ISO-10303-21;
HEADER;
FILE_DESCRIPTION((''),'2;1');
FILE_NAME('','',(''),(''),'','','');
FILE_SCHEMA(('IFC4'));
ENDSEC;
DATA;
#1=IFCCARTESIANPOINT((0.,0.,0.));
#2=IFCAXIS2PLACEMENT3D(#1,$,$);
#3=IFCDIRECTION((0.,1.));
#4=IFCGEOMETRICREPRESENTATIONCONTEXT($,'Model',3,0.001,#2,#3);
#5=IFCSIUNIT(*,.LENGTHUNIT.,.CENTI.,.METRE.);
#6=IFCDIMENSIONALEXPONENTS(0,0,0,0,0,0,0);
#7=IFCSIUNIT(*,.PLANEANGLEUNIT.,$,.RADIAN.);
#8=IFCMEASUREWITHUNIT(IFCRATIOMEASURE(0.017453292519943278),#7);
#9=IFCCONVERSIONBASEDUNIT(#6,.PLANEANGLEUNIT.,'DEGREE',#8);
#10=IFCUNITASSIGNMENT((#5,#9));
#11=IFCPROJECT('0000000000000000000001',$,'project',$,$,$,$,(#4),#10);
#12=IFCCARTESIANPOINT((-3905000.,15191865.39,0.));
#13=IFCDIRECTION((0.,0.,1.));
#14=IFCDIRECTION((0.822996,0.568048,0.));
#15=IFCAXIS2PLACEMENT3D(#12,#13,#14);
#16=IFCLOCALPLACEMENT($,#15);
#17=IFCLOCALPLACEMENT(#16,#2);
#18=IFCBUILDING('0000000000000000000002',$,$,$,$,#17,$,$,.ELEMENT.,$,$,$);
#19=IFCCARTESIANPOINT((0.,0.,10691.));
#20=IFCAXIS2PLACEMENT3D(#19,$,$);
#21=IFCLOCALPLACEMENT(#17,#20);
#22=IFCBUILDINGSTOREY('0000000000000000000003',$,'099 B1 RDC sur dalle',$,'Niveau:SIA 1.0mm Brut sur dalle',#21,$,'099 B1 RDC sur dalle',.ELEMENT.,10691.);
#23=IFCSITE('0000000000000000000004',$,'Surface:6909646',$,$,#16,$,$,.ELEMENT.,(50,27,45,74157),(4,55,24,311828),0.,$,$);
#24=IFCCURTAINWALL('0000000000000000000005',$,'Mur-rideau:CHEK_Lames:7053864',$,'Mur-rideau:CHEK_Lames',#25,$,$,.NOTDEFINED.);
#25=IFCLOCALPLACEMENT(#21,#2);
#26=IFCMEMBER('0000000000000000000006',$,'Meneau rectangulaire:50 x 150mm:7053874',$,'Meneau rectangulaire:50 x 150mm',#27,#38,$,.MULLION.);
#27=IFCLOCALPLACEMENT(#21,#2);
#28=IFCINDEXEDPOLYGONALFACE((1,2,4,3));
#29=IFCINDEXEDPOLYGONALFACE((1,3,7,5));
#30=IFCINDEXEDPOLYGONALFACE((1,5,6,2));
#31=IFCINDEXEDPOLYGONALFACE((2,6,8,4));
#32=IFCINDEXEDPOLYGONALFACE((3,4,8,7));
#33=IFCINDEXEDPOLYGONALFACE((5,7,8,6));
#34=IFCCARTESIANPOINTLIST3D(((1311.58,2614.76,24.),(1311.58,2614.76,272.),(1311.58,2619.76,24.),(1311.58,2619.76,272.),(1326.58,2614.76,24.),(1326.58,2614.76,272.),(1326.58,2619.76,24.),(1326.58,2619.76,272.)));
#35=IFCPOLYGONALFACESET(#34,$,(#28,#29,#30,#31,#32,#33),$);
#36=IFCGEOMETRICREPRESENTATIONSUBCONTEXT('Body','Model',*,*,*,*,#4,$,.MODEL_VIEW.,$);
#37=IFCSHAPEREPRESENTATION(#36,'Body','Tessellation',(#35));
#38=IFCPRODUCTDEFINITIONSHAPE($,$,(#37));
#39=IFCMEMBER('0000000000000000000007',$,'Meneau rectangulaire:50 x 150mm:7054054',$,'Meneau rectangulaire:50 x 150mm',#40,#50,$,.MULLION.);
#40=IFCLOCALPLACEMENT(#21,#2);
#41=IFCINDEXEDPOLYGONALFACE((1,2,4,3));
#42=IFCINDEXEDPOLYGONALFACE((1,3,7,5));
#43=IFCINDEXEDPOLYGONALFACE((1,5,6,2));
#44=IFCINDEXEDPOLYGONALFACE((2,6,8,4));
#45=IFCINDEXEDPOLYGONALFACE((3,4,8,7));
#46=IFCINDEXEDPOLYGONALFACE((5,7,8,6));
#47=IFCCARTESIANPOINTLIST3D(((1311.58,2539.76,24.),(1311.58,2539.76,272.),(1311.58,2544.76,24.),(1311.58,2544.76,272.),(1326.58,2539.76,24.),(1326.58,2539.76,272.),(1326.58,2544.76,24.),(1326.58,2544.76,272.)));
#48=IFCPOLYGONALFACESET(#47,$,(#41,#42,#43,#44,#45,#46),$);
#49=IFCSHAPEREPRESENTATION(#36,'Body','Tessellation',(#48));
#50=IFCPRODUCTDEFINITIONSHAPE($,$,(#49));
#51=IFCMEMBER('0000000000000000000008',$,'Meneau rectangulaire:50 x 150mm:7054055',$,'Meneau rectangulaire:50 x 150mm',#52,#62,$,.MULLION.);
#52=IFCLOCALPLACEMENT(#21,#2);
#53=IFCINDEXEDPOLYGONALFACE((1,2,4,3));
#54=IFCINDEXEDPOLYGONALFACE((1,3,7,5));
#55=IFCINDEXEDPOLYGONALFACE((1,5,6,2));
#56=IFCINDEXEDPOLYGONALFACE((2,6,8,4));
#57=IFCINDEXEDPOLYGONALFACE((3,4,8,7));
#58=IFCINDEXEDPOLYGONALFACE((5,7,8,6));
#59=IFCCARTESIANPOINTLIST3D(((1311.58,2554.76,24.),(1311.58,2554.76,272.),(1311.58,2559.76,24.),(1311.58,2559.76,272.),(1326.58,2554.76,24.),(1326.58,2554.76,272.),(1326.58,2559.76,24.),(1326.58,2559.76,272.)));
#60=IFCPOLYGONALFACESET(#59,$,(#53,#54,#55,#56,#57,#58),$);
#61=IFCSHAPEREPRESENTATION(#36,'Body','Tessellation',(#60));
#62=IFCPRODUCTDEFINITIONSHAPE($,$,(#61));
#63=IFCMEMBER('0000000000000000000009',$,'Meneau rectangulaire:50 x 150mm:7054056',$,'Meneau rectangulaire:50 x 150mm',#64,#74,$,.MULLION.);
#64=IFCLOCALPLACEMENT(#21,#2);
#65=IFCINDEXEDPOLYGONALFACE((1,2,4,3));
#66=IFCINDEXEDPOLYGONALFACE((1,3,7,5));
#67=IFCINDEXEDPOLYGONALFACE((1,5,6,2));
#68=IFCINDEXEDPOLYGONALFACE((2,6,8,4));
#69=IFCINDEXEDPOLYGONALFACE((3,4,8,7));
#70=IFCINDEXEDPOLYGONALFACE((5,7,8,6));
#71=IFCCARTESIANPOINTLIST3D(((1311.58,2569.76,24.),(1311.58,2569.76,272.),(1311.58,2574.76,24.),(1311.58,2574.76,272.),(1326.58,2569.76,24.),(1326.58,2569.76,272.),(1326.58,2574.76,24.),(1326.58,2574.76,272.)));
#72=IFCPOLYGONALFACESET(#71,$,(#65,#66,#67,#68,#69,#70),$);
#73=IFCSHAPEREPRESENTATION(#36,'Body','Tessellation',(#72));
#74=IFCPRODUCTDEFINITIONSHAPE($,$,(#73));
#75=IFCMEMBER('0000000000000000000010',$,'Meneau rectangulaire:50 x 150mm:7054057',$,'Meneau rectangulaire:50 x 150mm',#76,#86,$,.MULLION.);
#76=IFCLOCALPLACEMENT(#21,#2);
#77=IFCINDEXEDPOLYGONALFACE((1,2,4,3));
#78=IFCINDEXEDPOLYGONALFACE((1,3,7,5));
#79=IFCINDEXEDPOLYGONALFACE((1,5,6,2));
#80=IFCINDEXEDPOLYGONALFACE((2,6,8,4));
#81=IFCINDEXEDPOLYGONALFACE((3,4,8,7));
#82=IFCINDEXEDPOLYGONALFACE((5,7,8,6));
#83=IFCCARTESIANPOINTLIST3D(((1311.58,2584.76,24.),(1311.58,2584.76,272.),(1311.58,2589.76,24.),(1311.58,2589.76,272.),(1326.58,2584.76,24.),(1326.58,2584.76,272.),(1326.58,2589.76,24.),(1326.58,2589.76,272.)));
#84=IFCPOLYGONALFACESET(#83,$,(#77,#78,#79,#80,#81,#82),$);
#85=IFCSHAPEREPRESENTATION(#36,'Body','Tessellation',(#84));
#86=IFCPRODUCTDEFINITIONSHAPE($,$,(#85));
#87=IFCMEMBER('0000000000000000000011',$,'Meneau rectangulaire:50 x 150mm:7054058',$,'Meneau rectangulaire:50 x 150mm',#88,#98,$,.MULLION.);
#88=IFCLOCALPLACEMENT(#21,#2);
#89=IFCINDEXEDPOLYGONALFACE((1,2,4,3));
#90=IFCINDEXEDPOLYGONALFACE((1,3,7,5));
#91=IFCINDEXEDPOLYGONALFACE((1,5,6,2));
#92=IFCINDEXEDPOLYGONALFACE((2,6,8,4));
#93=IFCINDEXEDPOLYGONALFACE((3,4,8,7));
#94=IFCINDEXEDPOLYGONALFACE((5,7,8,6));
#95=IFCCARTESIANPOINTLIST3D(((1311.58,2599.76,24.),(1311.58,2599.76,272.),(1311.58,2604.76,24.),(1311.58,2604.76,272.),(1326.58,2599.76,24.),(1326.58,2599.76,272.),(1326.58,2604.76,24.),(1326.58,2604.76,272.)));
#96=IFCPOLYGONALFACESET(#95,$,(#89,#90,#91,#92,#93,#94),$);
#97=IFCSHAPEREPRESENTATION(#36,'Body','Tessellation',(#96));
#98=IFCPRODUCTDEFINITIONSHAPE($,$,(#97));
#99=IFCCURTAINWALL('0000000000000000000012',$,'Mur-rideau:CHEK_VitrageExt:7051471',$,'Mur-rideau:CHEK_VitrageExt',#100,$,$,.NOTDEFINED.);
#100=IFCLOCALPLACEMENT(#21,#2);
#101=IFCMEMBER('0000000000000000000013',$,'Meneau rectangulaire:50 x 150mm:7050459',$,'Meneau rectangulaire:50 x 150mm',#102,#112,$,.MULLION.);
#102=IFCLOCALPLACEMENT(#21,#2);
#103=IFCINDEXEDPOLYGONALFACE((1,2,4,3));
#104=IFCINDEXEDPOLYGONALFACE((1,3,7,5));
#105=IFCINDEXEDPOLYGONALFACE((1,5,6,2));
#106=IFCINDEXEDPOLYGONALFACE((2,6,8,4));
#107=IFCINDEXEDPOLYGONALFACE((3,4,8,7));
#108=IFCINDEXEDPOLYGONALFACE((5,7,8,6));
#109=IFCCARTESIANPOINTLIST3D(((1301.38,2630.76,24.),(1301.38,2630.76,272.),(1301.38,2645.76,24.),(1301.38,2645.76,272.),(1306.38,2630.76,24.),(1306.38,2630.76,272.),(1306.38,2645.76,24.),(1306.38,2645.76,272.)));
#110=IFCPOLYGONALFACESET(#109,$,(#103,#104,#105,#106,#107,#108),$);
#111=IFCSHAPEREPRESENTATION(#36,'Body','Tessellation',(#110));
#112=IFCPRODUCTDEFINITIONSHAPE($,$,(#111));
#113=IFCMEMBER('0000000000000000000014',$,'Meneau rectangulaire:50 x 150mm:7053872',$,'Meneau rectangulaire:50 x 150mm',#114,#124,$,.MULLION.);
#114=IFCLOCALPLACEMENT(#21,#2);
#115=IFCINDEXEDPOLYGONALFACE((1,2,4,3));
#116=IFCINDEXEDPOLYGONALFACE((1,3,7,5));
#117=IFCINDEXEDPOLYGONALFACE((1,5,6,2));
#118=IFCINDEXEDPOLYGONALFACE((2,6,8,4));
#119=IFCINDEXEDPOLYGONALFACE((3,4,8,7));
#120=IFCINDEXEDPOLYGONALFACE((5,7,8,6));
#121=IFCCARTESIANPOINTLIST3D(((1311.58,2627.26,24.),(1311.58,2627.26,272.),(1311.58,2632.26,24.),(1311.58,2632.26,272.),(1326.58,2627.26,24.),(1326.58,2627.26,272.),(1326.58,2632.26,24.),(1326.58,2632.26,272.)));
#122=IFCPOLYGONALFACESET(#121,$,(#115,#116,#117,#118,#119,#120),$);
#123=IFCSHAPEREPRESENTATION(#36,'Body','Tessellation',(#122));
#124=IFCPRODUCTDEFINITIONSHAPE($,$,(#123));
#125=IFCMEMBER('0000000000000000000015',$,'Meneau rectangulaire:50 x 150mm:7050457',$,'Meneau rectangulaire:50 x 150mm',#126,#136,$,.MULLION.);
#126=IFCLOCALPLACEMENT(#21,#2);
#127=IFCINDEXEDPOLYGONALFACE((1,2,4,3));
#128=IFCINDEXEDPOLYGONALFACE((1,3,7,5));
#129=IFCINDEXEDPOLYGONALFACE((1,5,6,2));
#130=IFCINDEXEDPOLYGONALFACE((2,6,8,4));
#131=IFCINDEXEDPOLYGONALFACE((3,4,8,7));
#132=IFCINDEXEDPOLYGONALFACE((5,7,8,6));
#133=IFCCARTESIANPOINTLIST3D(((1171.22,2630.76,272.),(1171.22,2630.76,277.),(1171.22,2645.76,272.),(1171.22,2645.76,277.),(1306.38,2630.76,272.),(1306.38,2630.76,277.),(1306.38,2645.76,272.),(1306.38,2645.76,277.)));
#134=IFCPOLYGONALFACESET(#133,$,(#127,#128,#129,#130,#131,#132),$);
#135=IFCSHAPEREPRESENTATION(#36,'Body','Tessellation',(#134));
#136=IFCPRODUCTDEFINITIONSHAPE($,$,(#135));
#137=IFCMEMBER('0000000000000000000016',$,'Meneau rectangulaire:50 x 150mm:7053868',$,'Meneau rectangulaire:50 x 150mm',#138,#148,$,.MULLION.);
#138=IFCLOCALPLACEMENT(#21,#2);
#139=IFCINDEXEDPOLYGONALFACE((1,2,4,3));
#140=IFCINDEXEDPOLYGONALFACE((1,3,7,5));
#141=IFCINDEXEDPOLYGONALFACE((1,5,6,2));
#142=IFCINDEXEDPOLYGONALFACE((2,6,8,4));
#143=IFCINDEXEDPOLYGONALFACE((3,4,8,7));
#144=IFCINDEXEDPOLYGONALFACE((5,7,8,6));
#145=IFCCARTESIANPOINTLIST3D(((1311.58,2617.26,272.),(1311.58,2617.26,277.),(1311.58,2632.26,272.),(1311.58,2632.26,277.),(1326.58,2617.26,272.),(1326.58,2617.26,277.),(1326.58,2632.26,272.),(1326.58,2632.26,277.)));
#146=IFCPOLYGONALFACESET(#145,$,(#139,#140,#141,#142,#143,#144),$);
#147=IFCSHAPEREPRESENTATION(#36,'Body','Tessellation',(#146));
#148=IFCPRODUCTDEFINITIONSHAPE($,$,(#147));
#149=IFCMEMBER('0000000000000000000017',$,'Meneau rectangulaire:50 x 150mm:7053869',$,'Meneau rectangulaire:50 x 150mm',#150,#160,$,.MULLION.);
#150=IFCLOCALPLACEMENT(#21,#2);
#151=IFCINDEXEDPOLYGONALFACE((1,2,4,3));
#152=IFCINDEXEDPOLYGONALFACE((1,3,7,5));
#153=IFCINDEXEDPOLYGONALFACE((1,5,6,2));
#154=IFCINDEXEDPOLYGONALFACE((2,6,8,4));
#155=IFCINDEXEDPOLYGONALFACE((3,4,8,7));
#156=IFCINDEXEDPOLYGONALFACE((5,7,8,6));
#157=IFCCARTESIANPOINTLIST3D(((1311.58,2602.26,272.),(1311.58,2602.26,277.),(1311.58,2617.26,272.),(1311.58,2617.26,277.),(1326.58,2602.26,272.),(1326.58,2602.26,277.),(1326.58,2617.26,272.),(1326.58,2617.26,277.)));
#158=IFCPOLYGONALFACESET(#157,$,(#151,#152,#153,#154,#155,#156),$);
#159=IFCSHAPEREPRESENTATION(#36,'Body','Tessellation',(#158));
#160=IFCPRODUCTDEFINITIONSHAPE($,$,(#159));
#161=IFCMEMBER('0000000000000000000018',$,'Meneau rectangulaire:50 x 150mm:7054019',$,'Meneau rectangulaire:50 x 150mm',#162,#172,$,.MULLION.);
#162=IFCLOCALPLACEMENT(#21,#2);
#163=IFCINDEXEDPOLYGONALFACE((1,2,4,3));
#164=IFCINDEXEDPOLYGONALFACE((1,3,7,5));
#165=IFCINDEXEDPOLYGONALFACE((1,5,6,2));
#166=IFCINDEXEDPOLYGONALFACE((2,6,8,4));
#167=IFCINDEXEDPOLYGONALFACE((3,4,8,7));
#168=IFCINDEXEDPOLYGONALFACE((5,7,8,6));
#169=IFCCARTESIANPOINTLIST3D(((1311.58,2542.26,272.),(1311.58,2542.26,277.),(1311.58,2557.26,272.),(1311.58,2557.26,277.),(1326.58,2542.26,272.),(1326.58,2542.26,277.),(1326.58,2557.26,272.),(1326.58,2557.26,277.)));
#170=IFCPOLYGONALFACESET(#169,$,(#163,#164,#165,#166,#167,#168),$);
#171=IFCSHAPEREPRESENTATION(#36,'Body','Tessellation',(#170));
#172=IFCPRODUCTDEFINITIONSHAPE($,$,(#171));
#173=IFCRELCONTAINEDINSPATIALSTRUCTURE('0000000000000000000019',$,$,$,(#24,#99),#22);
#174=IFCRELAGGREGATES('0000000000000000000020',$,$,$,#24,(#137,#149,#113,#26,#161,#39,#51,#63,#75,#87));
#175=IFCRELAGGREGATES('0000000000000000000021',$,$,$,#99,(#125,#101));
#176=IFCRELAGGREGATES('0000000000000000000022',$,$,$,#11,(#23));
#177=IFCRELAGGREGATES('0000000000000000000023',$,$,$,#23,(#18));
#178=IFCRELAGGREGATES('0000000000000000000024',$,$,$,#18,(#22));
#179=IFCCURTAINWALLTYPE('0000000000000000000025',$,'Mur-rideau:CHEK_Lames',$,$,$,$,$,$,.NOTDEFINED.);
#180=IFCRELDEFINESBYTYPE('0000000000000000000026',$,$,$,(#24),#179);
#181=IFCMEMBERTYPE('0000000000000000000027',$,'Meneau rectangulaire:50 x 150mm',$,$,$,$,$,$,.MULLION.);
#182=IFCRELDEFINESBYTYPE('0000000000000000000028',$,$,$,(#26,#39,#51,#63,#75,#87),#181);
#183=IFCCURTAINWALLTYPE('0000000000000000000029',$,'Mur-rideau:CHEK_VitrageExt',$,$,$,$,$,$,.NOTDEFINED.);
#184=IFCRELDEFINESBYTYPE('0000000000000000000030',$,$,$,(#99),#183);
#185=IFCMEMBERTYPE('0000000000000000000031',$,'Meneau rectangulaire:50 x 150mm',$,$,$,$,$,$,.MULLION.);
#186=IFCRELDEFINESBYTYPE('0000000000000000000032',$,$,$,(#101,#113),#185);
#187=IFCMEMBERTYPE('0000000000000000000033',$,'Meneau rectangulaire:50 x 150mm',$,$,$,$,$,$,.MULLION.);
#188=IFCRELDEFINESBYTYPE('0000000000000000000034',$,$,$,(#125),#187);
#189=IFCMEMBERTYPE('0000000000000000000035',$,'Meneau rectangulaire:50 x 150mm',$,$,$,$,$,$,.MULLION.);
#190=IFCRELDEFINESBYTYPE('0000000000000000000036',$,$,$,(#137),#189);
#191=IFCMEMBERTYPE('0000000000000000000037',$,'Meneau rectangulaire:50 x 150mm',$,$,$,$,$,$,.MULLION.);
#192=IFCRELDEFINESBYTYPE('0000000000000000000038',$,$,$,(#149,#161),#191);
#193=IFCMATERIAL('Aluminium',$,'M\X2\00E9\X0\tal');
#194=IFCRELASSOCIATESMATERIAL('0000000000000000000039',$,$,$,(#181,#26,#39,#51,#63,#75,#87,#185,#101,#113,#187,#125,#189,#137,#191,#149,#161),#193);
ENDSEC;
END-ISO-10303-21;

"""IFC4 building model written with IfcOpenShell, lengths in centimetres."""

from ifc_helpers import new_model, entity, si_unit, converted_unit, direction, frame, origin, place, context, subcontext, project, spatial, indexed_curve, outline, extrude, source, transform, mapped, material, type_object, type_shapes, element, aggregate, save


model = new_model("IFC4")

# Units and contexts
model_context = context("Model", 3, precision=0.001, world=origin(), true_north=direction((0.0, 1.0)))
body_context = subcontext(model_context, "Body", "Model", "MODEL_VIEW")
ifc_project = project(units=[si_unit("LENGTHUNIT", "METRE", prefix="CENTI"), converted_unit("PLANEANGLEUNIT", "DEGREE", entity("IfcRatioMeasure", 0.017453292519943278), si_unit("PLANEANGLEUNIT", "RADIAN"), dimensions=[0, 0, 0, 0, 0, 0, 0])], contexts=[model_context])

# Site, building, storey
site_placement = place(None, frame((-3905000.0, 15191865.39, 0.0), z_axis=(0.0, 0.0, 1.0), x_axis=(0.822996, 0.568048, 0.0)))
site = spatial("IfcSite", under=ifc_project, at=site_placement, Name="Surface:6909646", CompositionType="ELEMENT", RefLatitude=(50, 27, 45, 74157), RefLongitude=(4, 55, 24, 311828), RefElevation=0.0)
building_placement = place(site_placement, origin())
building = spatial("IfcBuilding", under=site, at=building_placement, CompositionType="ELEMENT")
storey_placement = place(building_placement, frame((0.0, 0.0, 10691.0)))
storey = spatial("IfcBuildingStorey", under=building, at=storey_placement, Name="099 B1 RDC sur dalle", ObjectType="Niveau:SIA 1.0mm Brut sur dalle", LongName="099 B1 RDC sur dalle", CompositionType="ELEMENT", Elevation=10691.0)

# Curtain wall, members
curtain_wall_type_1 = type_object("IfcCurtainWallType", Name="Mur-rideau:CHEK_Lames", PredefinedType="NOTDEFINED")
curtain_wall_1_placement = place(storey_placement, frame((0.0, 0.0, -10691.0)))
curtain_wall_1 = element("IfcCurtainWall", 1, at=curtain_wall_1_placement, inside=storey, type_object=curtain_wall_type_1, Name="Mur-rideau:CHEK_Lames:7053864", ObjectType="Mur-rideau:CHEK_Lames", PredefinedType="NOTDEFINED")
ifc_material_1 = material(Name="Aluminium", Category="Métal")
member_type_1 = type_object("IfcMemberType", Name="Meneau rectangulaire:50 x 150mm", PredefinedType="MULLION", material=ifc_material_1)
shared_shape_1 = source(origin(), body_context, "Body", "SweptSolid", [
    extrude(outline(indexed_curve([(-7.5, -2.5), (7.5, -2.5), (7.5, 2.5), (-7.5, 2.5), (-7.5, -2.5)], self_intersect=False)), frame((0.0, -6.0, -248.0), z_axis=(0.0, 0.0, 1.0), x_axis=(0.0, -1.0, 0.0)), (0.0, 0.0, 1.0), 248.0),
])
type_shapes(member_type_1, [shared_shape_1])
member_1_placement = place(curtain_wall_1_placement, frame((1325.08, 2617.26, 10715.0), z_axis=(0.0, 0.0, -1.0), x_axis=(0.0, 1.0, 0.0)))
member_1 = element("IfcMember", 2, at=member_1_placement, type_object=member_type_1, material=ifc_material_1, Name="Meneau rectangulaire:50 x 150mm:7053874", ObjectType="Meneau rectangulaire:50 x 150mm", PredefinedType="MULLION", context=body_context, shape_type="MappedRepresentation", body=[
    mapped(shared_shape_1, transform((0.0, 0.0, 0.0), scale=1.0)),
])
member_2_placement = place(curtain_wall_1_placement, frame((1325.08, 2542.26, 10715.0), z_axis=(0.0, 0.0, -1.0), x_axis=(0.0, 1.0, 0.0)))
member_2 = element("IfcMember", 3, at=member_2_placement, type_object=member_type_1, material=ifc_material_1, Name="Meneau rectangulaire:50 x 150mm:7054054", ObjectType="Meneau rectangulaire:50 x 150mm", PredefinedType="MULLION", context=body_context, shape_type="MappedRepresentation", body=[
    mapped(shared_shape_1, transform((0.0, 0.0, 0.0), scale=1.0)),
])
member_3_placement = place(curtain_wall_1_placement, frame((1325.08, 2557.26, 10715.0), z_axis=(0.0, 0.0, -1.0), x_axis=(0.0, 1.0, 0.0)))
member_3 = element("IfcMember", 4, at=member_3_placement, type_object=member_type_1, material=ifc_material_1, Name="Meneau rectangulaire:50 x 150mm:7054055", ObjectType="Meneau rectangulaire:50 x 150mm", PredefinedType="MULLION", context=body_context, shape_type="MappedRepresentation", body=[
    mapped(shared_shape_1, transform((0.0, 0.0, 0.0), scale=1.0)),
])
member_4_placement = place(curtain_wall_1_placement, frame((1325.08, 2572.26, 10715.0), z_axis=(0.0, 0.0, -1.0), x_axis=(0.0, 1.0, 0.0)))
member_4 = element("IfcMember", 5, at=member_4_placement, type_object=member_type_1, material=ifc_material_1, Name="Meneau rectangulaire:50 x 150mm:7054056", ObjectType="Meneau rectangulaire:50 x 150mm", PredefinedType="MULLION", context=body_context, shape_type="MappedRepresentation", body=[
    mapped(shared_shape_1, transform((0.0, 0.0, 0.0), scale=1.0)),
])
member_5_placement = place(curtain_wall_1_placement, frame((1325.08, 2587.26, 10715.0), z_axis=(0.0, 0.0, -1.0), x_axis=(0.0, 1.0, 0.0)))
member_5 = element("IfcMember", 6, at=member_5_placement, type_object=member_type_1, material=ifc_material_1, Name="Meneau rectangulaire:50 x 150mm:7054057", ObjectType="Meneau rectangulaire:50 x 150mm", PredefinedType="MULLION", context=body_context, shape_type="MappedRepresentation", body=[
    mapped(shared_shape_1, transform((0.0, 0.0, 0.0), scale=1.0)),
])
member_6_placement = place(curtain_wall_1_placement, frame((1325.08, 2602.26, 10715.0), z_axis=(0.0, 0.0, -1.0), x_axis=(0.0, 1.0, 0.0)))
member_6 = element("IfcMember", 7, at=member_6_placement, type_object=member_type_1, material=ifc_material_1, Name="Meneau rectangulaire:50 x 150mm:7054058", ObjectType="Meneau rectangulaire:50 x 150mm", PredefinedType="MULLION", context=body_context, shape_type="MappedRepresentation", body=[
    mapped(shared_shape_1, transform((0.0, 0.0, 0.0), scale=1.0)),
])

# Curtain wall, member
curtain_wall_type_2 = type_object("IfcCurtainWallType", Name="Mur-rideau:CHEK_VitrageExt", PredefinedType="NOTDEFINED")
curtain_wall_2_placement = place(storey_placement, frame((0.0, 0.0, -10691.0)))
curtain_wall_2 = element("IfcCurtainWall", 8, at=curtain_wall_2_placement, inside=storey, type_object=curtain_wall_type_2, Name="Mur-rideau:CHEK_VitrageExt:7051471", ObjectType="Mur-rideau:CHEK_VitrageExt", PredefinedType="NOTDEFINED")
member_type_2 = type_object("IfcMemberType", Name="Meneau rectangulaire:50 x 150mm", PredefinedType="MULLION", material=ifc_material_1)
shared_shape_2 = source(origin(), body_context, "Body", "SweptSolid", [
    extrude(outline(indexed_curve([(-7.5, -2.5), (7.5, -2.5), (7.5, 2.5), (-7.5, 2.5), (-7.5, -2.5)], self_intersect=False)), frame((-2.5, -6.0, -248.0), z_axis=(0.0, 0.0, 1.0), x_axis=(0.0, -1.0, 0.0)), (0.0, 0.0, 1.0), 248.0),
])
type_shapes(member_type_2, [shared_shape_2])
member_7_placement = place(curtain_wall_2_placement, frame((1306.38, 2632.26, 10715.0), z_axis=(0.0, 0.0, -1.0), x_axis=(1.0, 0.0, 0.0)))
member_7 = element("IfcMember", 9, at=member_7_placement, type_object=member_type_2, material=ifc_material_1, Name="Meneau rectangulaire:50 x 150mm:7050459", ObjectType="Meneau rectangulaire:50 x 150mm", PredefinedType="MULLION", context=body_context, shape_type="MappedRepresentation", body=[
    mapped(shared_shape_2, transform((0.0, 0.0, 0.0), scale=1.0)),
])

# Members
member_8_placement = place(curtain_wall_1_placement, frame((1325.08, 2632.26, 10715.0), z_axis=(0.0, 0.0, -1.0), x_axis=(0.0, 1.0, 0.0)))
member_8 = element("IfcMember", 10, at=member_8_placement, type_object=member_type_2, material=ifc_material_1, Name="Meneau rectangulaire:50 x 150mm:7053872", ObjectType="Meneau rectangulaire:50 x 150mm", PredefinedType="MULLION", context=body_context, shape_type="MappedRepresentation", body=[
    mapped(shared_shape_2, transform((0.0, 0.0, 0.0), scale=1.0)),
])
member_type_3 = type_object("IfcMemberType", Name="Meneau rectangulaire:50 x 150mm", PredefinedType="MULLION", material=ifc_material_1)
shared_shape_3 = source(origin(), body_context, "Body", "SweptSolid", [
    extrude(outline(indexed_curve([(-7.5, -2.5), (7.5, -2.5), (7.5, 2.5), (-7.5, 2.5), (-7.5, -2.5)], self_intersect=False)), frame((-2.5, -6.0, -135.15), z_axis=(0.0, 0.0, 1.0), x_axis=(0.0, -1.0, 0.0)), (0.0, 0.0, 1.0), 135.15),
])
type_shapes(member_type_3, [shared_shape_3])
member_9_placement = place(curtain_wall_2_placement, frame((1306.38, 2632.26, 10968.0), z_axis=(1.0, 0.0, 0.0), x_axis=(0.0, 0.0, 1.0)))
member_9 = element("IfcMember", 11, at=member_9_placement, type_object=member_type_3, material=ifc_material_1, Name="Meneau rectangulaire:50 x 150mm:7050457", ObjectType="Meneau rectangulaire:50 x 150mm", PredefinedType="MULLION", context=body_context, shape_type="MappedRepresentation", body=[
    mapped(shared_shape_3, transform((0.0, 0.0, 0.0), scale=1.0)),
])
member_type_4 = type_object("IfcMemberType", Name="Meneau rectangulaire:50 x 150mm", PredefinedType="MULLION", material=ifc_material_1)
shared_shape_4 = source(origin(), body_context, "Body", "SweptSolid", [
    extrude(outline(indexed_curve([(-7.5, -2.5), (7.5, -2.5), (7.5, 2.5), (-7.5, 2.5), (-7.5, -2.5)], self_intersect=False)), frame((-2.5, -6.0, -15.0), z_axis=(0.0, 0.0, 1.0), x_axis=(0.0, -1.0, 0.0)), (0.0, 0.0, 1.0), 15.0),
])
type_shapes(member_type_4, [shared_shape_4])
member_10_placement = place(curtain_wall_1_placement, frame((1325.08, 2632.26, 10968.0), z_axis=(0.0, 1.0, 0.0), x_axis=(0.0, 0.0, 1.0)))
member_10 = element("IfcMember", 12, at=member_10_placement, type_object=member_type_4, material=ifc_material_1, Name="Meneau rectangulaire:50 x 150mm:7053868", ObjectType="Meneau rectangulaire:50 x 150mm", PredefinedType="MULLION", context=body_context, shape_type="MappedRepresentation", body=[
    mapped(shared_shape_4, transform((0.0, 0.0, 0.0), scale=1.0)),
])
member_type_5 = type_object("IfcMemberType", Name="Meneau rectangulaire:50 x 150mm", PredefinedType="MULLION", material=ifc_material_1)
shared_shape_5 = source(origin(), body_context, "Body", "SweptSolid", [
    extrude(outline(indexed_curve([(-7.5, -2.5), (7.5, -2.5), (7.5, 2.5), (-7.5, 2.5), (-7.5, -2.5)], self_intersect=False)), frame((-2.5, -6.0, -15.0), z_axis=(0.0, 0.0, 1.0), x_axis=(0.0, -1.0, 0.0)), (0.0, 0.0, 1.0), 15.0),
])
type_shapes(member_type_5, [shared_shape_5])
member_11_placement = place(curtain_wall_1_placement, frame((1325.08, 2617.26, 10968.0), z_axis=(0.0, 1.0, 0.0), x_axis=(0.0, 0.0, 1.0)))
member_11 = element("IfcMember", 13, at=member_11_placement, type_object=member_type_5, material=ifc_material_1, Name="Meneau rectangulaire:50 x 150mm:7053869", ObjectType="Meneau rectangulaire:50 x 150mm", PredefinedType="MULLION", context=body_context, shape_type="MappedRepresentation", body=[
    mapped(shared_shape_5, transform((0.0, 0.0, 0.0), scale=1.0)),
])
member_12_placement = place(curtain_wall_1_placement, frame((1325.08, 2557.26, 10968.0), z_axis=(0.0, 1.0, 0.0), x_axis=(0.0, 0.0, 1.0)))
member_12 = element("IfcMember", 14, at=member_12_placement, type_object=member_type_5, material=ifc_material_1, Name="Meneau rectangulaire:50 x 150mm:7054019", ObjectType="Meneau rectangulaire:50 x 150mm", PredefinedType="MULLION", context=body_context, shape_type="MappedRepresentation", body=[
    mapped(shared_shape_5, transform((0.0, 0.0, 0.0), scale=1.0)),
])
aggregate(curtain_wall_1, [member_10, member_11, member_8, member_1, member_12, member_2, member_3, member_4, member_5, member_6])

aggregate(curtain_wall_2, [member_9, member_7])

save(model, "model.ifc")
